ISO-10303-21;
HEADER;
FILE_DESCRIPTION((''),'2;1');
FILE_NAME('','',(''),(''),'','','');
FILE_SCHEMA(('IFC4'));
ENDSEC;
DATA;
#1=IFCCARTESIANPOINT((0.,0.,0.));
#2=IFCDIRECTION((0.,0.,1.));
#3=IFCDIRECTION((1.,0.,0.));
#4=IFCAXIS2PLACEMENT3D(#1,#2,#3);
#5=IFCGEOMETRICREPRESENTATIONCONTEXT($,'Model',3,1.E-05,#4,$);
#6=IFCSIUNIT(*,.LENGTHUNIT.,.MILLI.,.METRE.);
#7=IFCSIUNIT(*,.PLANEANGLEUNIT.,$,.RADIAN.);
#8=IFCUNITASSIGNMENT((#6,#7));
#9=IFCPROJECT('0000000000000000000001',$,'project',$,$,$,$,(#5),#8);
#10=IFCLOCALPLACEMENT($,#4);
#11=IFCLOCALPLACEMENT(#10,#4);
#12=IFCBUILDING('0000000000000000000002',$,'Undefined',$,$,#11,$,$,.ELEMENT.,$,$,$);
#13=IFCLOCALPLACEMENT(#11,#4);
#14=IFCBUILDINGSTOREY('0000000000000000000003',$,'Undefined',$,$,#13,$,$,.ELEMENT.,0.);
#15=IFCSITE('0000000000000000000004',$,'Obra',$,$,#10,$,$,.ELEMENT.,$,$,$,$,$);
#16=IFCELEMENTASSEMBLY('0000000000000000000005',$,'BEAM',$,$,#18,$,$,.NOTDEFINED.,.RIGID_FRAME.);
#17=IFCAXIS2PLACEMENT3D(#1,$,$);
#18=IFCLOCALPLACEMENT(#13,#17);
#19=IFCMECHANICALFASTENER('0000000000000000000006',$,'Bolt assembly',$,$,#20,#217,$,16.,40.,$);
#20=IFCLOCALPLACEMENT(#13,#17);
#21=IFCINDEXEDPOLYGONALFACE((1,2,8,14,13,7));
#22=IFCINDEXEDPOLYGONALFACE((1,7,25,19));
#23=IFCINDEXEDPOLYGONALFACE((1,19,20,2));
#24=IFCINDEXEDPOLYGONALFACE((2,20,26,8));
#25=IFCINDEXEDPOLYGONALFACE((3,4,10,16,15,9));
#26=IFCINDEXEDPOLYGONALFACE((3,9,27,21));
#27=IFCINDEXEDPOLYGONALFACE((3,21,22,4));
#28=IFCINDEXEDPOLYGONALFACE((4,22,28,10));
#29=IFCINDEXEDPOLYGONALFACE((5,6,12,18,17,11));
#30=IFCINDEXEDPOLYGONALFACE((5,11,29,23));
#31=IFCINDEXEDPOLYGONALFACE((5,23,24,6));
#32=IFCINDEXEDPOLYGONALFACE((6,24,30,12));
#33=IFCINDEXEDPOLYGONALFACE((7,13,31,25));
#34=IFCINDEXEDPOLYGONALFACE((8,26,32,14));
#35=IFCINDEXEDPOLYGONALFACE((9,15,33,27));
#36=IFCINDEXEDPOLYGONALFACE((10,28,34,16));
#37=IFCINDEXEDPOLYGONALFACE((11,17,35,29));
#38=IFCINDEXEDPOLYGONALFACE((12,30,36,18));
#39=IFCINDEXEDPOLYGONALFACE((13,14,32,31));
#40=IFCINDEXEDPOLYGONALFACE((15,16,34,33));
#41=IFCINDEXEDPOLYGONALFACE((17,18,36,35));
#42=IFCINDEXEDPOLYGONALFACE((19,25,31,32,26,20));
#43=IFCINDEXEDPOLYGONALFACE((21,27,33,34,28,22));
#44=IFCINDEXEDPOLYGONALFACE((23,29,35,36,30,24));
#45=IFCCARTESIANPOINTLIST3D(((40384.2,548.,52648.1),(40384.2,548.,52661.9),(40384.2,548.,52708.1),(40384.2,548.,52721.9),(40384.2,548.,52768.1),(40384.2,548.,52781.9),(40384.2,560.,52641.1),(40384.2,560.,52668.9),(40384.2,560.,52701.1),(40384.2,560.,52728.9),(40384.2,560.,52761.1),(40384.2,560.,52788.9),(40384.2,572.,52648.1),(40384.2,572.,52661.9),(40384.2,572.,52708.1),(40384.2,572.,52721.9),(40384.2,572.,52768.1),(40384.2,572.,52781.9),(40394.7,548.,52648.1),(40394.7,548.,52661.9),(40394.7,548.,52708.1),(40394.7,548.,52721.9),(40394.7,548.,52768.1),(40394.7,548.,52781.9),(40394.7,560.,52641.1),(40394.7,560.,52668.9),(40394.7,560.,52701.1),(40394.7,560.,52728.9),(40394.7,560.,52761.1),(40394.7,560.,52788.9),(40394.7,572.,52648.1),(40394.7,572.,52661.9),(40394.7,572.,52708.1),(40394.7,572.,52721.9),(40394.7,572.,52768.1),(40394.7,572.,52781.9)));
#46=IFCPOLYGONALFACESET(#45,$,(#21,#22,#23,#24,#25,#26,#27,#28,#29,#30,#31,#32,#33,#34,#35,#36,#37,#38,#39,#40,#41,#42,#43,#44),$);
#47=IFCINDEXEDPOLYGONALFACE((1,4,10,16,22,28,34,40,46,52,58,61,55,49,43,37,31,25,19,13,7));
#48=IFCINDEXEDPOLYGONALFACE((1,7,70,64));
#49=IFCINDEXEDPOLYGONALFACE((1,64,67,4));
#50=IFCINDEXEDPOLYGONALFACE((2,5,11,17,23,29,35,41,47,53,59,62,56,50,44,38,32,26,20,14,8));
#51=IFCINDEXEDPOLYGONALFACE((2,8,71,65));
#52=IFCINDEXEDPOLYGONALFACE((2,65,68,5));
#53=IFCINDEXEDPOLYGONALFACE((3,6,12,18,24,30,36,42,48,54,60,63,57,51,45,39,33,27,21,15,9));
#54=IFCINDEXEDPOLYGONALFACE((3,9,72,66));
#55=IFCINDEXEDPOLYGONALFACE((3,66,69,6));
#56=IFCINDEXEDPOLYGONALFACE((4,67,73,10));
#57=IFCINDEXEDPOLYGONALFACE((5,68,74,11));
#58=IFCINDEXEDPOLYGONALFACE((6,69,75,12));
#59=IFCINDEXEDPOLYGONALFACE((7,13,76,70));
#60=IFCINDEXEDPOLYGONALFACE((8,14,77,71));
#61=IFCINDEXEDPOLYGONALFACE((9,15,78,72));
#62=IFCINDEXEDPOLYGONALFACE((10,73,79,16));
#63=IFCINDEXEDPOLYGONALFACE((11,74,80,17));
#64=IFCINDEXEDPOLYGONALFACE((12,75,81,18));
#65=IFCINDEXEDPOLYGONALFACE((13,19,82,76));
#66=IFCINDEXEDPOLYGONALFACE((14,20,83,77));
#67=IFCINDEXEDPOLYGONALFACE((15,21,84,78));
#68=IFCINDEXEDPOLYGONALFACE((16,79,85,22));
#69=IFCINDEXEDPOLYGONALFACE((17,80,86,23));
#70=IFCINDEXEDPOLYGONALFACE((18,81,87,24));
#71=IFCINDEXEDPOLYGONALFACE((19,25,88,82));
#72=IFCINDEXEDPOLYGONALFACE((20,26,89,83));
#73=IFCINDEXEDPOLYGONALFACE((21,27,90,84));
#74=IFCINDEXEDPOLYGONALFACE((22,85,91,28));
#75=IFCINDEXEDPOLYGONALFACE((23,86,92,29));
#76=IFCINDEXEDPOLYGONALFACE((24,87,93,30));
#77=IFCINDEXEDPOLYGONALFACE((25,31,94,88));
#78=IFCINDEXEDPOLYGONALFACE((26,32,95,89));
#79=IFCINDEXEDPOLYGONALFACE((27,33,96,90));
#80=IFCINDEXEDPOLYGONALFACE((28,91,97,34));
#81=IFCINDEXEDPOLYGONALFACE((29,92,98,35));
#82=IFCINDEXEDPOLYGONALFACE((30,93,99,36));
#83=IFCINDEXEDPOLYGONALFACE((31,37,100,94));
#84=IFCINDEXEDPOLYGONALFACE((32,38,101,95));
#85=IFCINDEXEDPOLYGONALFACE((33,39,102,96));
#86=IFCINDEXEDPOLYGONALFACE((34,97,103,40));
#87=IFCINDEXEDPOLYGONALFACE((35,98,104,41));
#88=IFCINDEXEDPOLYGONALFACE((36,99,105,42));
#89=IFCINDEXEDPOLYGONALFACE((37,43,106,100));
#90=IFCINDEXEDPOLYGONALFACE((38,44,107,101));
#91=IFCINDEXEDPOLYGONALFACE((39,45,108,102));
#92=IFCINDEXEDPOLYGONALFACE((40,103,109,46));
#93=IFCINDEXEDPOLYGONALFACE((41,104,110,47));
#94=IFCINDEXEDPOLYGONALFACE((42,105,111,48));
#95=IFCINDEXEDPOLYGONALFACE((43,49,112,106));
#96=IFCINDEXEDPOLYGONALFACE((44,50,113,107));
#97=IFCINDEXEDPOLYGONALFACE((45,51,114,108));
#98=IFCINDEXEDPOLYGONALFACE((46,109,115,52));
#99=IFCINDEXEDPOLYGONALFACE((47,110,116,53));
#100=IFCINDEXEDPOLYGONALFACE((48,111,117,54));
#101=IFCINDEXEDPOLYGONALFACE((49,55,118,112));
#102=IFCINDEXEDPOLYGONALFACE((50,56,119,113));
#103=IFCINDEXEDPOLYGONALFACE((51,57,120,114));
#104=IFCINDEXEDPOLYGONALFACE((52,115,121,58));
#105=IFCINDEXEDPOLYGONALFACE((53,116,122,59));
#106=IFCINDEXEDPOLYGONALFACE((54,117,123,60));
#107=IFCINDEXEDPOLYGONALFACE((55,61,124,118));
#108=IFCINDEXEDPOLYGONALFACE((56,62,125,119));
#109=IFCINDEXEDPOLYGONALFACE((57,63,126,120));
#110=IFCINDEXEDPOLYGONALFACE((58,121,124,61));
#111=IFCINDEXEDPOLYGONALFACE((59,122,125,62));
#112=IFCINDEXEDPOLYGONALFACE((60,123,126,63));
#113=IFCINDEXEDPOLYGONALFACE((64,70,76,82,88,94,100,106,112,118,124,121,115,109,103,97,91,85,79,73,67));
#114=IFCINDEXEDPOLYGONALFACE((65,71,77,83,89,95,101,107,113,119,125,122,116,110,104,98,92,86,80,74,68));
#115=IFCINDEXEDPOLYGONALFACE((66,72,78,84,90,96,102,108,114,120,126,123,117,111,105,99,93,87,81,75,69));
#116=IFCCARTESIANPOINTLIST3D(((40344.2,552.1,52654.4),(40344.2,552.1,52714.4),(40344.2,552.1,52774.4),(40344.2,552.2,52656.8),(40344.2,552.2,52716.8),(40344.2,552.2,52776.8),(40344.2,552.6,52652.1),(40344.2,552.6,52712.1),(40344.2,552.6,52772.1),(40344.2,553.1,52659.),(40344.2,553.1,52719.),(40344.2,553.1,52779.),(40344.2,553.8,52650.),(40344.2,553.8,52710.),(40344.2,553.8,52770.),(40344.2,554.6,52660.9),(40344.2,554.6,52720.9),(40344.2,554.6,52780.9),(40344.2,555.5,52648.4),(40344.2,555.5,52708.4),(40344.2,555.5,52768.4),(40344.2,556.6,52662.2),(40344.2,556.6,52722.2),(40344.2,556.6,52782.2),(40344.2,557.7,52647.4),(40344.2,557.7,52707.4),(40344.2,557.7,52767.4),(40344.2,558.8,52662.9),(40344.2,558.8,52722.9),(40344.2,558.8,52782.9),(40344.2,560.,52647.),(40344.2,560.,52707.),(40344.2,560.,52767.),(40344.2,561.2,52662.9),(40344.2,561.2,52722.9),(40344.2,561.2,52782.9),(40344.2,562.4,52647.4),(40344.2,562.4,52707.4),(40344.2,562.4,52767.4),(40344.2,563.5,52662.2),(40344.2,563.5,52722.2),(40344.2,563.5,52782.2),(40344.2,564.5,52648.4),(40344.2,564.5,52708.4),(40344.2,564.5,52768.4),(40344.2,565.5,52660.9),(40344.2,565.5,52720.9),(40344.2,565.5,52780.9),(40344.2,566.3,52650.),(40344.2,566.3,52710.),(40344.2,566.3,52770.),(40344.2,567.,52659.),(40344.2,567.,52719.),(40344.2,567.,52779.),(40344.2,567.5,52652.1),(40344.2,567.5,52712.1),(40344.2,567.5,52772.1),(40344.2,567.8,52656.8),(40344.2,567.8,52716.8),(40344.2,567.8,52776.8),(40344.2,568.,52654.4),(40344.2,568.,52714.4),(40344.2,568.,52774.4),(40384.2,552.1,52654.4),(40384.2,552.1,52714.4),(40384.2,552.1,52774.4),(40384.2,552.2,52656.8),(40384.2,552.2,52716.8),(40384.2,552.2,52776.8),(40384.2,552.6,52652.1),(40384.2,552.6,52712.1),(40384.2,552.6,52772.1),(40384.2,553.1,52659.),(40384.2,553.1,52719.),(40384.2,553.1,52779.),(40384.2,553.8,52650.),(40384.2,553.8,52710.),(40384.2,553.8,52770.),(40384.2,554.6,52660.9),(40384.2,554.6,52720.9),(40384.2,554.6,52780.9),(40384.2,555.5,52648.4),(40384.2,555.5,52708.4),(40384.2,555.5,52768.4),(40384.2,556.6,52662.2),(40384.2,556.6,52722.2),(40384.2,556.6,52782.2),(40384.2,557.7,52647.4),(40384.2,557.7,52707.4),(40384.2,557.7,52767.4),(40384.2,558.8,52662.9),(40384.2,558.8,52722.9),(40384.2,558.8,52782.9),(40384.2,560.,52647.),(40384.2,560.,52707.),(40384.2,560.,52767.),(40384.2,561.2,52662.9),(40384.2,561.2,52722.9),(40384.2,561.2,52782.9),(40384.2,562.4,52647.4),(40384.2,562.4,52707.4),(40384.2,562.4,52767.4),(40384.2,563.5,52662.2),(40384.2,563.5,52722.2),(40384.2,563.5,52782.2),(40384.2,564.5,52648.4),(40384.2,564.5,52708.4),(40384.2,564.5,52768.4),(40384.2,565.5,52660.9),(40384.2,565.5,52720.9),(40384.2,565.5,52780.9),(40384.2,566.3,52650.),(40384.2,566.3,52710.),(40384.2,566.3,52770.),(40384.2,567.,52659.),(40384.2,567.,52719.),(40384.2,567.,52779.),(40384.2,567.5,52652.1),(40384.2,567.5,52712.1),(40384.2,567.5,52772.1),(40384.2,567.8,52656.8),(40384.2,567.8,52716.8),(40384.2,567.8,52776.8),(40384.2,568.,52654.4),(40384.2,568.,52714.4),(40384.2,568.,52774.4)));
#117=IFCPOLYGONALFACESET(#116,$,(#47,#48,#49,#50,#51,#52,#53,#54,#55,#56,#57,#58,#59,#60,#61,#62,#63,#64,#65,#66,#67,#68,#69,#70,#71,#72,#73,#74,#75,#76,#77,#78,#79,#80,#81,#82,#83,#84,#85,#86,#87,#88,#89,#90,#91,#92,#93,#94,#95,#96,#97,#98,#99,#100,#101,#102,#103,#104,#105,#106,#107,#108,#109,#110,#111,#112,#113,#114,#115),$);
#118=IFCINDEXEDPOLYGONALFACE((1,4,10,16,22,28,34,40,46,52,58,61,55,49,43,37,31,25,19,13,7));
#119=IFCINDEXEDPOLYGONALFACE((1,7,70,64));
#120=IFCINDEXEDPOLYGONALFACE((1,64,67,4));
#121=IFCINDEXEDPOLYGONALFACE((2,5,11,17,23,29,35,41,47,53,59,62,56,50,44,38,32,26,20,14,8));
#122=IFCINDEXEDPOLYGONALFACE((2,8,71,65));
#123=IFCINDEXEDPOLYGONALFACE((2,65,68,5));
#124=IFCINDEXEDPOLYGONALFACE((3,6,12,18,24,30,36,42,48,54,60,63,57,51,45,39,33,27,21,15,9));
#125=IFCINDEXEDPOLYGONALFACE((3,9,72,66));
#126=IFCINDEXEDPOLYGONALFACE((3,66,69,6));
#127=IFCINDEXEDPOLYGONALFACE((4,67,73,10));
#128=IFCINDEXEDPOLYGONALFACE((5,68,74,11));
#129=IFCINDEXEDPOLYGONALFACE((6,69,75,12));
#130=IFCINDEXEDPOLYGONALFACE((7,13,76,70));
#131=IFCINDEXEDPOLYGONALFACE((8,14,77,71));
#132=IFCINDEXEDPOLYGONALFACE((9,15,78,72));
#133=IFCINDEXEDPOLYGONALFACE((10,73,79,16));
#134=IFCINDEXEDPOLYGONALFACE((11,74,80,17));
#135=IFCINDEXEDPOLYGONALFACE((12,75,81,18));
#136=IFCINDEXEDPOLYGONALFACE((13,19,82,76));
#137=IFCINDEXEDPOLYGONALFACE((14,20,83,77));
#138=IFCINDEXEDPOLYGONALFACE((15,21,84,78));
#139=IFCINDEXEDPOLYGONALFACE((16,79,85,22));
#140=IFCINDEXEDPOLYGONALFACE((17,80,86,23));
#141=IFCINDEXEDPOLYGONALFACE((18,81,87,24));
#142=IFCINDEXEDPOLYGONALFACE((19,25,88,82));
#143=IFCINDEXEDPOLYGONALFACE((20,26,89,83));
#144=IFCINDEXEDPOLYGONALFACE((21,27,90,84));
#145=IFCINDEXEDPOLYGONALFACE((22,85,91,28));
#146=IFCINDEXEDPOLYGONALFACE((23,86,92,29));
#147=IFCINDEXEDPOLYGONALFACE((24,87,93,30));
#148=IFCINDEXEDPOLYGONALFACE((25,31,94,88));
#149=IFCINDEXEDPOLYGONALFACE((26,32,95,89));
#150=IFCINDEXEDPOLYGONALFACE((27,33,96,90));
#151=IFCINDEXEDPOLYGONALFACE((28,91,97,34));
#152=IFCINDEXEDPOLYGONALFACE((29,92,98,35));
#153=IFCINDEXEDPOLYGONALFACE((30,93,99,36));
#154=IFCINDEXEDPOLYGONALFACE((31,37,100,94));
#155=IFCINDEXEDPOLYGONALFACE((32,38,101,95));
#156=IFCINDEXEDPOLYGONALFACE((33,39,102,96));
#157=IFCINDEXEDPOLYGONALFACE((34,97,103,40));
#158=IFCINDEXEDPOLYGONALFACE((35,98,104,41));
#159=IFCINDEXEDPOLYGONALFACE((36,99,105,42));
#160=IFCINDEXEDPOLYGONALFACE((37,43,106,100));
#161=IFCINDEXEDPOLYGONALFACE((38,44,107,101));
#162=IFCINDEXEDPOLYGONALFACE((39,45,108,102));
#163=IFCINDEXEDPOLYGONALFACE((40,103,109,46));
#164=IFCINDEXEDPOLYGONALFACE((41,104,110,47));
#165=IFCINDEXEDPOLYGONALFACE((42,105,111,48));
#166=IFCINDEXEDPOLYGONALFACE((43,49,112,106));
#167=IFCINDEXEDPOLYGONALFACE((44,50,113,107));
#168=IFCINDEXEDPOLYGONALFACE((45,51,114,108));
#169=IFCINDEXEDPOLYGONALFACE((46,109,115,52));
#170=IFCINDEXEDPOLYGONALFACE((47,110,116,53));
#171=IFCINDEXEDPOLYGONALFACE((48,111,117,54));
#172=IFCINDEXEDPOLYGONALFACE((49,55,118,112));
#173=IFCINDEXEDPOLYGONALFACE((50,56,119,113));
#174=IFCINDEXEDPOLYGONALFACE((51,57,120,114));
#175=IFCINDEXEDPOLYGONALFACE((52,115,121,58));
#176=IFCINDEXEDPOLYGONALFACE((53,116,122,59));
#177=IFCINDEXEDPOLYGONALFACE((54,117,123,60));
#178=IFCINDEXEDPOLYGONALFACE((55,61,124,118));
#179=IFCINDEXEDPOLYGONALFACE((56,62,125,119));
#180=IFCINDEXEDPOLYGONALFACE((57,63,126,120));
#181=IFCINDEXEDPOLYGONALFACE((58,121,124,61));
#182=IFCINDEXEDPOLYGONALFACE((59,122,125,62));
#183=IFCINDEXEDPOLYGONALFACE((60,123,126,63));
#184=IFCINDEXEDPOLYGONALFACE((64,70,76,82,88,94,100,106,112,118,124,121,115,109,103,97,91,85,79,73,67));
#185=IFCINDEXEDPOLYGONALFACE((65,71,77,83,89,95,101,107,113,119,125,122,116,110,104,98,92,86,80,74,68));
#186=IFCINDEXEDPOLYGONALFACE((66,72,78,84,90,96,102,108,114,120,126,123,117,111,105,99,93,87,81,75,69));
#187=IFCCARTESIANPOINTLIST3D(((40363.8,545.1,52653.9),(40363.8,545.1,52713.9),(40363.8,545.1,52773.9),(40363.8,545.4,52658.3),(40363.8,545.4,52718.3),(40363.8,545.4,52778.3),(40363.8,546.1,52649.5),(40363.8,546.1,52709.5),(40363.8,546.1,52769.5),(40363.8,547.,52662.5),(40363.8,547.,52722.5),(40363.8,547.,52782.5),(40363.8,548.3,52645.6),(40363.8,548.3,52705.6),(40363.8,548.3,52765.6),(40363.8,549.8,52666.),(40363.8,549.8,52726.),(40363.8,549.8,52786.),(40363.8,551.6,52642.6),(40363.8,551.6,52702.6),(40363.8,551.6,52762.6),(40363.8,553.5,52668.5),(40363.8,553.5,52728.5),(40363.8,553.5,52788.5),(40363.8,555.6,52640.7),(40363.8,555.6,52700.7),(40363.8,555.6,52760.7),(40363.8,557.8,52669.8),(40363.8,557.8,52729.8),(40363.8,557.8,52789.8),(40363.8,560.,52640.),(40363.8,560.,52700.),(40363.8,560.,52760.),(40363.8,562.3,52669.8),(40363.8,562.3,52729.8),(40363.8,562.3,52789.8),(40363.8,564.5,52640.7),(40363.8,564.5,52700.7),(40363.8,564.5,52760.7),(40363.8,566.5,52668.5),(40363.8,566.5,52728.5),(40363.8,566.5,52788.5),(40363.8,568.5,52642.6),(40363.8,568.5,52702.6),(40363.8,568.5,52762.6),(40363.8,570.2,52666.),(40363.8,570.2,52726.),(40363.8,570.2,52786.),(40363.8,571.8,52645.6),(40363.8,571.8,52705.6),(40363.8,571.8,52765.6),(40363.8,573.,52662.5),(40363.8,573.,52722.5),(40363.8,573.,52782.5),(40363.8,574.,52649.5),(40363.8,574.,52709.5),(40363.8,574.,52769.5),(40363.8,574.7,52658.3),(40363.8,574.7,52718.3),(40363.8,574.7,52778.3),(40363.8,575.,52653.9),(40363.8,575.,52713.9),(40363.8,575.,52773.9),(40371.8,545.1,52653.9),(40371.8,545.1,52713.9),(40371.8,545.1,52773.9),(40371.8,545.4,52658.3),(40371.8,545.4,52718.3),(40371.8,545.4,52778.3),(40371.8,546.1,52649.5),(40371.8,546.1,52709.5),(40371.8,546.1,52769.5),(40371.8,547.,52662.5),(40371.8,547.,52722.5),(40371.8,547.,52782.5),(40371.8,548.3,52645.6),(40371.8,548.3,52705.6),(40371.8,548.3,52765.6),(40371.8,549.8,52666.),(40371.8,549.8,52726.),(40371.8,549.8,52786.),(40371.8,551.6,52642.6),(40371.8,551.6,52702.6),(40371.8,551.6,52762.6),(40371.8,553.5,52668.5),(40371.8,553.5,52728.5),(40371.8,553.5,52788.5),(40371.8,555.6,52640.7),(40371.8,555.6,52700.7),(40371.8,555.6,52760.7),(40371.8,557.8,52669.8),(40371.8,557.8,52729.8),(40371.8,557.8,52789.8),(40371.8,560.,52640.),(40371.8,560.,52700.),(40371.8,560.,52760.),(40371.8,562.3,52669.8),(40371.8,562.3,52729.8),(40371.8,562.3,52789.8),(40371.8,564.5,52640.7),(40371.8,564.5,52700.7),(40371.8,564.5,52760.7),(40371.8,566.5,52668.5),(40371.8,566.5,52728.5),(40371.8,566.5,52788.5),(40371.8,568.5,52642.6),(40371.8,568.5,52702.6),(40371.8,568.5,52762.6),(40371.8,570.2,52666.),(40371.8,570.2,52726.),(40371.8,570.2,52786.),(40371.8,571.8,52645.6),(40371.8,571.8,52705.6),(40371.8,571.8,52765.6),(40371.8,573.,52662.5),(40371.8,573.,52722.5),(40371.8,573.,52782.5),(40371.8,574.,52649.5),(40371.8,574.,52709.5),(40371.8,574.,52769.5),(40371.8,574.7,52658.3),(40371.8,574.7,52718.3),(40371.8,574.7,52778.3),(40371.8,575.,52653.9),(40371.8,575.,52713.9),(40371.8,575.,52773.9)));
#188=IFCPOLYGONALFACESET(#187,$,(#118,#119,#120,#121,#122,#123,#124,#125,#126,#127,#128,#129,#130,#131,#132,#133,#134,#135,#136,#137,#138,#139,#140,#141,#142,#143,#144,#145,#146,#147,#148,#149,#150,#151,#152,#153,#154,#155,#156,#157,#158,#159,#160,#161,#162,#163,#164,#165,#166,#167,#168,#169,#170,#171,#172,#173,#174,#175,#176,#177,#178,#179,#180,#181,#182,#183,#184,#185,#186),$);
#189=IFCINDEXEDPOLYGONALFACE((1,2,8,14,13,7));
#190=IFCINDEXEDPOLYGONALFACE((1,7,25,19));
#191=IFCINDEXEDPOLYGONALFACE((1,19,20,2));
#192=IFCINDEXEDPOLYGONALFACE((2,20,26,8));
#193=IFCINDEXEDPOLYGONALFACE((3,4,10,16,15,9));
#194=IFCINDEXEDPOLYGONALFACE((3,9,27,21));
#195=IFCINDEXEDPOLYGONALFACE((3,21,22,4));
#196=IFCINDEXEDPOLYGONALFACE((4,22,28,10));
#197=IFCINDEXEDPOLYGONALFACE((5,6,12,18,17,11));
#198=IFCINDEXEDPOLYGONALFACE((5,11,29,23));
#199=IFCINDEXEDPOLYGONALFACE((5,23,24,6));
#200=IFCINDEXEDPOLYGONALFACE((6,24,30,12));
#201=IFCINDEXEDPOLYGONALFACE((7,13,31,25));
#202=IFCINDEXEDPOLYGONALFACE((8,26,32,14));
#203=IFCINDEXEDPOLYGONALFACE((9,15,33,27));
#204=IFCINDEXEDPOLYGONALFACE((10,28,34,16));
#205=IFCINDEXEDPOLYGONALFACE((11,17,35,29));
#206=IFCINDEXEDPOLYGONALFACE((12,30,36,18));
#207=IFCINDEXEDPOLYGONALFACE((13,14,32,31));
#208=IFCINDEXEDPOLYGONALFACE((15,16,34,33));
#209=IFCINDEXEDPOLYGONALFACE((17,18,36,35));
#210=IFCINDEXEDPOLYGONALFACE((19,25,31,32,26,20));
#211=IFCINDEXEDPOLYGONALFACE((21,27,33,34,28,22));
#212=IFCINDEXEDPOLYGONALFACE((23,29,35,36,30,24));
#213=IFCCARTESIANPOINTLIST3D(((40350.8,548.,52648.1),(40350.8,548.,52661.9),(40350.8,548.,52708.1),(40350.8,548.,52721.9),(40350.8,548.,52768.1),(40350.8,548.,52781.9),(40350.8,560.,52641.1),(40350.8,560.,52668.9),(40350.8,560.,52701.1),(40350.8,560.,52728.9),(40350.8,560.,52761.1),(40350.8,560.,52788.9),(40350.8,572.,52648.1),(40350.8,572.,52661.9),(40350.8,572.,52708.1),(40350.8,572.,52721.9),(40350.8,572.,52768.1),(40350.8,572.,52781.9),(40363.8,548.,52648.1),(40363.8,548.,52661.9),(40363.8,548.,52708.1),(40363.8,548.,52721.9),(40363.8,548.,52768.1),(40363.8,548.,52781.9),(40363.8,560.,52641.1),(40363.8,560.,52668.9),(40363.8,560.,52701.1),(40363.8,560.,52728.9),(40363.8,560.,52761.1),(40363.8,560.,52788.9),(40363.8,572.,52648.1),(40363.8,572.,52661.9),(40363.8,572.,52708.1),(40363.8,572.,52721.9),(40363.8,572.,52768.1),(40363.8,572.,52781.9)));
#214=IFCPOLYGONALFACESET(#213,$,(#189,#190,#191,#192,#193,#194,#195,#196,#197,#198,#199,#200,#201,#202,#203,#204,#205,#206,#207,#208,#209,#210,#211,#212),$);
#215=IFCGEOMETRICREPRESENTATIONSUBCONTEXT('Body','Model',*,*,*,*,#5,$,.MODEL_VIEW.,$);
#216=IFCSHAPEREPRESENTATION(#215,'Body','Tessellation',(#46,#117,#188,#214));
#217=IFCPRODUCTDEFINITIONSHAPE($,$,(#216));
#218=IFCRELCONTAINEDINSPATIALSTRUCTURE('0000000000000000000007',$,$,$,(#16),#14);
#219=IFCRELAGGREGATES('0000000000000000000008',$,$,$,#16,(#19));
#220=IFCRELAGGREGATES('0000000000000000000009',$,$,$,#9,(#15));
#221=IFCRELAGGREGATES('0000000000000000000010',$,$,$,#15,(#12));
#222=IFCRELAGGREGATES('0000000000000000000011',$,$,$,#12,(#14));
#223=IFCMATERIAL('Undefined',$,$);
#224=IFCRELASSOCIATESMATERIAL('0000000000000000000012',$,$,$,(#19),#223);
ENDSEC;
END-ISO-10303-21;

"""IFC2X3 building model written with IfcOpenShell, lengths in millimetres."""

from ifc_helpers import new_model, si_unit, frame, origin_with_axes, origin_2d_with_axis, place, context, subcontext, project, spatial, polyline, circle, outline, extrude, source, transform, mapped, material, element, aggregate, save


model = new_model("IFC2X3")

# Units and contexts
model_context = context("Model", 3, precision=1e-05, world=origin_with_axes())
body_context = subcontext(model_context, "Body", "Model", "MODEL_VIEW")
ifc_project = project(units=[si_unit("LENGTHUNIT", "METRE", prefix="MILLI"), si_unit("PLANEANGLEUNIT", "RADIAN")], contexts=[model_context])

# Site, building, storey
site_placement = place(None, origin_with_axes())
site = spatial("IfcSite", under=ifc_project, at=site_placement, Name="Obra", CompositionType="ELEMENT")
building_placement = place(site_placement, origin_with_axes())
building = spatial("IfcBuilding", under=site, at=building_placement, Name="Undefined", CompositionType="ELEMENT")
storey_placement = place(building_placement, origin_with_axes())
storey = spatial("IfcBuildingStorey", under=building, at=storey_placement, Name="Undefined", CompositionType="ELEMENT", Elevation=0.0)

# Element assembly
assembly_1_placement = place(storey_placement, origin_with_axes())
assembly_1 = element("IfcElementAssembly", 1, at=assembly_1_placement, inside=storey, Name="BEAM", AssemblyPlace="NOTDEFINED", PredefinedType="RIGID_FRAME")

# Shared definitions
ifc_material_1 = material(Name="Undefined")

# Mechanical fastener
shared_shape_1 = source(origin_with_axes(), body_context, "Body", "SweptSolid", [
    extrude(outline(polyline([(13.9, 0.0), (6.9, 12.0), (-6.9, 12.0), (-13.9, 0.0), (-6.9, -12.0), (6.9, -12.0), (13.9, 0.0)])), frame((0.0, -19.7, 0.0), z_axis=(0.0, 1.0, 0.0), x_axis=(1.0, 0.0, 0.0)), (0.0, 0.0, 1.0), 10.6),
    extrude(circle(Radius=8.0, at=origin_2d_with_axis()), frame((0.0, -9.1, 0.0), z_axis=(0.0, 1.0, 0.0), x_axis=(1.0, 0.0, 0.0)), (0.0, 0.0, 1.0), 40.0),
    extrude(circle(Radius=15.0, at=origin_2d_with_axis()), frame((0.0, 3.3, 0.0), z_axis=(0.0, 1.0, 0.0), x_axis=(1.0, 0.0, 0.0)), (0.0, 0.0, 1.0), 8.0),
    extrude(outline(polyline([(13.9, 0.0), (6.9, 12.0), (-6.9, 12.0), (-13.9, 0.0), (-6.9, -12.0), (6.9, -12.0), (13.9, 0.0)])), frame((0.0, 11.3, 0.0), z_axis=(0.0, 1.0, 0.0), x_axis=(1.0, 0.0, 0.0)), (0.0, 0.0, 1.0), 13.0),
])
mechanical_fastener_1_placement = place(assembly_1_placement, frame((40375.1, 510.0, 52835.0), z_axis=(-0.000002, 1.0, 0.0), x_axis=(0.0, 0.0, -1.0)))
mechanical_fastener_1 = element("IfcMechanicalFastener", 2, at=mechanical_fastener_1_placement, material=ifc_material_1, Name="Bolt assembly", NominalDiameter=16.0, NominalLength=40.0, context=body_context, shape_type="MappedRepresentation", body=[
    mapped(shared_shape_1, transform((60.0, 0.0, 50.0))),
    mapped(shared_shape_1, transform((120.0, 0.0, 50.0))),
    mapped(shared_shape_1, transform((180.0, 0.0, 50.0))),
])
aggregate(assembly_1, [mechanical_fastener_1])

save(model, "model.ifc")
